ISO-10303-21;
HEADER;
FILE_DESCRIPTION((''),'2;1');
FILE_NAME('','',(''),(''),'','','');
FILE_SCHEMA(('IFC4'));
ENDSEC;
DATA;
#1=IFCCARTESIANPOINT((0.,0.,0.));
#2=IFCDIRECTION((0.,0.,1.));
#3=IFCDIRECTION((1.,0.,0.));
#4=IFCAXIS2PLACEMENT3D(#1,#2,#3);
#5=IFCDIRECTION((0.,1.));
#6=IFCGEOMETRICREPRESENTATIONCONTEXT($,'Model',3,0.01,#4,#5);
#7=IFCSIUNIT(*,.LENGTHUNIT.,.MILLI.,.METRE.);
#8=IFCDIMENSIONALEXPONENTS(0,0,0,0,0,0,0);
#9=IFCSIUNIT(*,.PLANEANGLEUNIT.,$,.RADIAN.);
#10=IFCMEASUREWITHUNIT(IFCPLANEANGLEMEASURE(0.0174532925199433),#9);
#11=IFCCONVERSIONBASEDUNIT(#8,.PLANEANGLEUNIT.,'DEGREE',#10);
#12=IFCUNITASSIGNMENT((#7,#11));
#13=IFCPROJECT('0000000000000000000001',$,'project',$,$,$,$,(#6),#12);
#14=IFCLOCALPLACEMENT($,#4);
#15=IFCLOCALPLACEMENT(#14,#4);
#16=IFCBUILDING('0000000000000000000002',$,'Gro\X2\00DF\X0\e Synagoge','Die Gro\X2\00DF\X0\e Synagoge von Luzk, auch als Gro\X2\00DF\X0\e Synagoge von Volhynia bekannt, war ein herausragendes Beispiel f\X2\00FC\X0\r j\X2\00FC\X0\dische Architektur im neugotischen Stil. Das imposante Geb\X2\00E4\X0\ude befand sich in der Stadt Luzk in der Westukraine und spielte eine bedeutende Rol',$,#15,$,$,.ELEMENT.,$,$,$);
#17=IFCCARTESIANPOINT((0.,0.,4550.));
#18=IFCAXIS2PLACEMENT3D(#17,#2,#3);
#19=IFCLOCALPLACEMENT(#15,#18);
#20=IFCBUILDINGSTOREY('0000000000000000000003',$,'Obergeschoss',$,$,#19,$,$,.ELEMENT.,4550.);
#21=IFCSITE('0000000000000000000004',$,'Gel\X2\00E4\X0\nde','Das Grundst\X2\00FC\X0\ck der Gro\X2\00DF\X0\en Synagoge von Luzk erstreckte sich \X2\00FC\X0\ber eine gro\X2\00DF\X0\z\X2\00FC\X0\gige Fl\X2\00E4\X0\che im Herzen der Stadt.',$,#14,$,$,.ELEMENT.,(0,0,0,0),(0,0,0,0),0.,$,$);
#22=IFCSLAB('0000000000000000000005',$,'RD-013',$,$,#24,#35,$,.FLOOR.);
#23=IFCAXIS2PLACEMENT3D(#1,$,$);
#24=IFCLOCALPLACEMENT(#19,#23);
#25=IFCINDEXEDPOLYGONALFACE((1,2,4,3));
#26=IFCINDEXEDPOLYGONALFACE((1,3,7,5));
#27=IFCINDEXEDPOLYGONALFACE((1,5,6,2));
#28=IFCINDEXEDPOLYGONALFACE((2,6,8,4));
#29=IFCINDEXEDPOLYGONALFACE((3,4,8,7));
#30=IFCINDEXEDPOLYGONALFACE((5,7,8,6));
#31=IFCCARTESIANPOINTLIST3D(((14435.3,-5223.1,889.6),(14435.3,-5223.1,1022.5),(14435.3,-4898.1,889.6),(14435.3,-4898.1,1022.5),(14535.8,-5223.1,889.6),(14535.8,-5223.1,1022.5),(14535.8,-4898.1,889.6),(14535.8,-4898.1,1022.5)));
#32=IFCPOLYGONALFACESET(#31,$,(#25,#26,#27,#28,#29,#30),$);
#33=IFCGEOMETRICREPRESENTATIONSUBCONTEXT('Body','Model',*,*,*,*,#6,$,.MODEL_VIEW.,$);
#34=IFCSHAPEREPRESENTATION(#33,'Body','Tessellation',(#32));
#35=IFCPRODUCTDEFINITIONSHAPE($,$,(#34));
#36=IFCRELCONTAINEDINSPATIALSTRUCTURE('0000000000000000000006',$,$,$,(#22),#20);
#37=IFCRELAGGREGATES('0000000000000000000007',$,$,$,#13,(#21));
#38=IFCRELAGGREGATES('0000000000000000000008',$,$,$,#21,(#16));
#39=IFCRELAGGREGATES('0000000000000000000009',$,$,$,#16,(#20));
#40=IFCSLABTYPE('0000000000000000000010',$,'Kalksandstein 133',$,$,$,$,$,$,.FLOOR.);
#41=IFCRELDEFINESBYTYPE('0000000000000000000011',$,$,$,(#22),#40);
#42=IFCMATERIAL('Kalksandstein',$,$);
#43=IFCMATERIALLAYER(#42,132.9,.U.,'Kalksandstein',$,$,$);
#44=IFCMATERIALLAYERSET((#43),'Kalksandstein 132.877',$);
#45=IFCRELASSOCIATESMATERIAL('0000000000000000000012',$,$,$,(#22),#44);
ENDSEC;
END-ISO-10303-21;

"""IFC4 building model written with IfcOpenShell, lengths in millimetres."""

from ifc_helpers import new_model, entity, si_unit, converted_unit, direction, frame, origin_with_axes, place, context, subcontext, project, spatial, line, indexed_curve, outline, extrude, material, layer, layer_set, layer_usage, type_object, element, save


model = new_model("IFC4")

# Units and contexts
model_context = context("Model", 3, precision=0.01, world=origin_with_axes(), true_north=direction((0.0, 1.0)))
body_context = subcontext(model_context, "Body", "Model", "MODEL_VIEW")
ifc_project = project(units=[si_unit("LENGTHUNIT", "METRE", prefix="MILLI"), converted_unit("PLANEANGLEUNIT", "DEGREE", entity("IfcPlaneAngleMeasure", 0.0174532925199433), si_unit("PLANEANGLEUNIT", "RADIAN"), dimensions=[0, 0, 0, 0, 0, 0, 0])], contexts=[model_context])

# Site, building, storey
site_placement = place(None, origin_with_axes())
site = spatial("IfcSite", under=ifc_project, at=site_placement, Name="Gelände", Description="Das Grundstück der Großen Synagoge von Luzk erstreckte sich über eine großzügige Fläche im Herzen der Stadt.", CompositionType="ELEMENT", RefLatitude=(0, 0, 0, 0), RefLongitude=(0, 0, 0, 0), RefElevation=0.0)
building_placement = place(site_placement, origin_with_axes())
building = spatial("IfcBuilding", under=site, at=building_placement, Name="Große Synagoge", Description="Die Große Synagoge von Luzk, auch als Große Synagoge von Volhynia bekannt, war ein herausragendes Beispiel für jüdische Architektur im neugotischen Stil. Das imposante Gebäude befand sich in der Stadt Luzk in der Westukraine und spielte eine bedeutende Rol", CompositionType="ELEMENT")
storey_placement = place(building_placement, frame((0.0, 0.0, 4550.0), z_axis=(0.0, 0.0, 1.0), x_axis=(1.0, 0.0, 0.0)))
storey = spatial("IfcBuildingStorey", under=building, at=storey_placement, Name="Obergeschoss", CompositionType="ELEMENT", Elevation=4550.0)

# Shared definitions
ifc_material_1 = material(Name="Kalksandstein")

# Slab
ifc_layer_1 = layer(ifc_material_1, 132.9, ventilated="UNKNOWN", Name="Kalksandstein")
ifc_layer_set_1 = layer_set([ifc_layer_1], Name="Kalksandstein 132.877")
slab_type_1 = type_object("IfcSlabType", Name="Kalksandstein 133", PredefinedType="FLOOR")
ifc_layer_usage_1 = layer_usage(ifc_layer_set_1, "AXIS3", "NEGATIVE", 132.9)
slab_1_placement = place(storey_placement, frame((14435.3, -4898.1, 1022.5), z_axis=(0.0, 0.0, 1.0), x_axis=(1.0, 0.0, 0.0)))
element("IfcSlab", 1, at=slab_1_placement, inside=storey, type_object=slab_type_1, material=ifc_layer_usage_1, Name="RD-013", PredefinedType="FLOOR", context=body_context, shape_type="SweptSolid", body=[
    extrude(outline(indexed_curve([(0.0, 0.0), (0.0, -325.0), (100.5, -325.0), (100.5, 0.0)], segments=[line(1, 2, 3, 4, 1)])), frame((0.0, 0.0, -132.9), z_axis=(0.0, 0.0, 1.0), x_axis=(1.0, 0.0, 0.0)), (0.0, 0.0, 1.0), 132.9),
])

save(model, "model.ifc")
